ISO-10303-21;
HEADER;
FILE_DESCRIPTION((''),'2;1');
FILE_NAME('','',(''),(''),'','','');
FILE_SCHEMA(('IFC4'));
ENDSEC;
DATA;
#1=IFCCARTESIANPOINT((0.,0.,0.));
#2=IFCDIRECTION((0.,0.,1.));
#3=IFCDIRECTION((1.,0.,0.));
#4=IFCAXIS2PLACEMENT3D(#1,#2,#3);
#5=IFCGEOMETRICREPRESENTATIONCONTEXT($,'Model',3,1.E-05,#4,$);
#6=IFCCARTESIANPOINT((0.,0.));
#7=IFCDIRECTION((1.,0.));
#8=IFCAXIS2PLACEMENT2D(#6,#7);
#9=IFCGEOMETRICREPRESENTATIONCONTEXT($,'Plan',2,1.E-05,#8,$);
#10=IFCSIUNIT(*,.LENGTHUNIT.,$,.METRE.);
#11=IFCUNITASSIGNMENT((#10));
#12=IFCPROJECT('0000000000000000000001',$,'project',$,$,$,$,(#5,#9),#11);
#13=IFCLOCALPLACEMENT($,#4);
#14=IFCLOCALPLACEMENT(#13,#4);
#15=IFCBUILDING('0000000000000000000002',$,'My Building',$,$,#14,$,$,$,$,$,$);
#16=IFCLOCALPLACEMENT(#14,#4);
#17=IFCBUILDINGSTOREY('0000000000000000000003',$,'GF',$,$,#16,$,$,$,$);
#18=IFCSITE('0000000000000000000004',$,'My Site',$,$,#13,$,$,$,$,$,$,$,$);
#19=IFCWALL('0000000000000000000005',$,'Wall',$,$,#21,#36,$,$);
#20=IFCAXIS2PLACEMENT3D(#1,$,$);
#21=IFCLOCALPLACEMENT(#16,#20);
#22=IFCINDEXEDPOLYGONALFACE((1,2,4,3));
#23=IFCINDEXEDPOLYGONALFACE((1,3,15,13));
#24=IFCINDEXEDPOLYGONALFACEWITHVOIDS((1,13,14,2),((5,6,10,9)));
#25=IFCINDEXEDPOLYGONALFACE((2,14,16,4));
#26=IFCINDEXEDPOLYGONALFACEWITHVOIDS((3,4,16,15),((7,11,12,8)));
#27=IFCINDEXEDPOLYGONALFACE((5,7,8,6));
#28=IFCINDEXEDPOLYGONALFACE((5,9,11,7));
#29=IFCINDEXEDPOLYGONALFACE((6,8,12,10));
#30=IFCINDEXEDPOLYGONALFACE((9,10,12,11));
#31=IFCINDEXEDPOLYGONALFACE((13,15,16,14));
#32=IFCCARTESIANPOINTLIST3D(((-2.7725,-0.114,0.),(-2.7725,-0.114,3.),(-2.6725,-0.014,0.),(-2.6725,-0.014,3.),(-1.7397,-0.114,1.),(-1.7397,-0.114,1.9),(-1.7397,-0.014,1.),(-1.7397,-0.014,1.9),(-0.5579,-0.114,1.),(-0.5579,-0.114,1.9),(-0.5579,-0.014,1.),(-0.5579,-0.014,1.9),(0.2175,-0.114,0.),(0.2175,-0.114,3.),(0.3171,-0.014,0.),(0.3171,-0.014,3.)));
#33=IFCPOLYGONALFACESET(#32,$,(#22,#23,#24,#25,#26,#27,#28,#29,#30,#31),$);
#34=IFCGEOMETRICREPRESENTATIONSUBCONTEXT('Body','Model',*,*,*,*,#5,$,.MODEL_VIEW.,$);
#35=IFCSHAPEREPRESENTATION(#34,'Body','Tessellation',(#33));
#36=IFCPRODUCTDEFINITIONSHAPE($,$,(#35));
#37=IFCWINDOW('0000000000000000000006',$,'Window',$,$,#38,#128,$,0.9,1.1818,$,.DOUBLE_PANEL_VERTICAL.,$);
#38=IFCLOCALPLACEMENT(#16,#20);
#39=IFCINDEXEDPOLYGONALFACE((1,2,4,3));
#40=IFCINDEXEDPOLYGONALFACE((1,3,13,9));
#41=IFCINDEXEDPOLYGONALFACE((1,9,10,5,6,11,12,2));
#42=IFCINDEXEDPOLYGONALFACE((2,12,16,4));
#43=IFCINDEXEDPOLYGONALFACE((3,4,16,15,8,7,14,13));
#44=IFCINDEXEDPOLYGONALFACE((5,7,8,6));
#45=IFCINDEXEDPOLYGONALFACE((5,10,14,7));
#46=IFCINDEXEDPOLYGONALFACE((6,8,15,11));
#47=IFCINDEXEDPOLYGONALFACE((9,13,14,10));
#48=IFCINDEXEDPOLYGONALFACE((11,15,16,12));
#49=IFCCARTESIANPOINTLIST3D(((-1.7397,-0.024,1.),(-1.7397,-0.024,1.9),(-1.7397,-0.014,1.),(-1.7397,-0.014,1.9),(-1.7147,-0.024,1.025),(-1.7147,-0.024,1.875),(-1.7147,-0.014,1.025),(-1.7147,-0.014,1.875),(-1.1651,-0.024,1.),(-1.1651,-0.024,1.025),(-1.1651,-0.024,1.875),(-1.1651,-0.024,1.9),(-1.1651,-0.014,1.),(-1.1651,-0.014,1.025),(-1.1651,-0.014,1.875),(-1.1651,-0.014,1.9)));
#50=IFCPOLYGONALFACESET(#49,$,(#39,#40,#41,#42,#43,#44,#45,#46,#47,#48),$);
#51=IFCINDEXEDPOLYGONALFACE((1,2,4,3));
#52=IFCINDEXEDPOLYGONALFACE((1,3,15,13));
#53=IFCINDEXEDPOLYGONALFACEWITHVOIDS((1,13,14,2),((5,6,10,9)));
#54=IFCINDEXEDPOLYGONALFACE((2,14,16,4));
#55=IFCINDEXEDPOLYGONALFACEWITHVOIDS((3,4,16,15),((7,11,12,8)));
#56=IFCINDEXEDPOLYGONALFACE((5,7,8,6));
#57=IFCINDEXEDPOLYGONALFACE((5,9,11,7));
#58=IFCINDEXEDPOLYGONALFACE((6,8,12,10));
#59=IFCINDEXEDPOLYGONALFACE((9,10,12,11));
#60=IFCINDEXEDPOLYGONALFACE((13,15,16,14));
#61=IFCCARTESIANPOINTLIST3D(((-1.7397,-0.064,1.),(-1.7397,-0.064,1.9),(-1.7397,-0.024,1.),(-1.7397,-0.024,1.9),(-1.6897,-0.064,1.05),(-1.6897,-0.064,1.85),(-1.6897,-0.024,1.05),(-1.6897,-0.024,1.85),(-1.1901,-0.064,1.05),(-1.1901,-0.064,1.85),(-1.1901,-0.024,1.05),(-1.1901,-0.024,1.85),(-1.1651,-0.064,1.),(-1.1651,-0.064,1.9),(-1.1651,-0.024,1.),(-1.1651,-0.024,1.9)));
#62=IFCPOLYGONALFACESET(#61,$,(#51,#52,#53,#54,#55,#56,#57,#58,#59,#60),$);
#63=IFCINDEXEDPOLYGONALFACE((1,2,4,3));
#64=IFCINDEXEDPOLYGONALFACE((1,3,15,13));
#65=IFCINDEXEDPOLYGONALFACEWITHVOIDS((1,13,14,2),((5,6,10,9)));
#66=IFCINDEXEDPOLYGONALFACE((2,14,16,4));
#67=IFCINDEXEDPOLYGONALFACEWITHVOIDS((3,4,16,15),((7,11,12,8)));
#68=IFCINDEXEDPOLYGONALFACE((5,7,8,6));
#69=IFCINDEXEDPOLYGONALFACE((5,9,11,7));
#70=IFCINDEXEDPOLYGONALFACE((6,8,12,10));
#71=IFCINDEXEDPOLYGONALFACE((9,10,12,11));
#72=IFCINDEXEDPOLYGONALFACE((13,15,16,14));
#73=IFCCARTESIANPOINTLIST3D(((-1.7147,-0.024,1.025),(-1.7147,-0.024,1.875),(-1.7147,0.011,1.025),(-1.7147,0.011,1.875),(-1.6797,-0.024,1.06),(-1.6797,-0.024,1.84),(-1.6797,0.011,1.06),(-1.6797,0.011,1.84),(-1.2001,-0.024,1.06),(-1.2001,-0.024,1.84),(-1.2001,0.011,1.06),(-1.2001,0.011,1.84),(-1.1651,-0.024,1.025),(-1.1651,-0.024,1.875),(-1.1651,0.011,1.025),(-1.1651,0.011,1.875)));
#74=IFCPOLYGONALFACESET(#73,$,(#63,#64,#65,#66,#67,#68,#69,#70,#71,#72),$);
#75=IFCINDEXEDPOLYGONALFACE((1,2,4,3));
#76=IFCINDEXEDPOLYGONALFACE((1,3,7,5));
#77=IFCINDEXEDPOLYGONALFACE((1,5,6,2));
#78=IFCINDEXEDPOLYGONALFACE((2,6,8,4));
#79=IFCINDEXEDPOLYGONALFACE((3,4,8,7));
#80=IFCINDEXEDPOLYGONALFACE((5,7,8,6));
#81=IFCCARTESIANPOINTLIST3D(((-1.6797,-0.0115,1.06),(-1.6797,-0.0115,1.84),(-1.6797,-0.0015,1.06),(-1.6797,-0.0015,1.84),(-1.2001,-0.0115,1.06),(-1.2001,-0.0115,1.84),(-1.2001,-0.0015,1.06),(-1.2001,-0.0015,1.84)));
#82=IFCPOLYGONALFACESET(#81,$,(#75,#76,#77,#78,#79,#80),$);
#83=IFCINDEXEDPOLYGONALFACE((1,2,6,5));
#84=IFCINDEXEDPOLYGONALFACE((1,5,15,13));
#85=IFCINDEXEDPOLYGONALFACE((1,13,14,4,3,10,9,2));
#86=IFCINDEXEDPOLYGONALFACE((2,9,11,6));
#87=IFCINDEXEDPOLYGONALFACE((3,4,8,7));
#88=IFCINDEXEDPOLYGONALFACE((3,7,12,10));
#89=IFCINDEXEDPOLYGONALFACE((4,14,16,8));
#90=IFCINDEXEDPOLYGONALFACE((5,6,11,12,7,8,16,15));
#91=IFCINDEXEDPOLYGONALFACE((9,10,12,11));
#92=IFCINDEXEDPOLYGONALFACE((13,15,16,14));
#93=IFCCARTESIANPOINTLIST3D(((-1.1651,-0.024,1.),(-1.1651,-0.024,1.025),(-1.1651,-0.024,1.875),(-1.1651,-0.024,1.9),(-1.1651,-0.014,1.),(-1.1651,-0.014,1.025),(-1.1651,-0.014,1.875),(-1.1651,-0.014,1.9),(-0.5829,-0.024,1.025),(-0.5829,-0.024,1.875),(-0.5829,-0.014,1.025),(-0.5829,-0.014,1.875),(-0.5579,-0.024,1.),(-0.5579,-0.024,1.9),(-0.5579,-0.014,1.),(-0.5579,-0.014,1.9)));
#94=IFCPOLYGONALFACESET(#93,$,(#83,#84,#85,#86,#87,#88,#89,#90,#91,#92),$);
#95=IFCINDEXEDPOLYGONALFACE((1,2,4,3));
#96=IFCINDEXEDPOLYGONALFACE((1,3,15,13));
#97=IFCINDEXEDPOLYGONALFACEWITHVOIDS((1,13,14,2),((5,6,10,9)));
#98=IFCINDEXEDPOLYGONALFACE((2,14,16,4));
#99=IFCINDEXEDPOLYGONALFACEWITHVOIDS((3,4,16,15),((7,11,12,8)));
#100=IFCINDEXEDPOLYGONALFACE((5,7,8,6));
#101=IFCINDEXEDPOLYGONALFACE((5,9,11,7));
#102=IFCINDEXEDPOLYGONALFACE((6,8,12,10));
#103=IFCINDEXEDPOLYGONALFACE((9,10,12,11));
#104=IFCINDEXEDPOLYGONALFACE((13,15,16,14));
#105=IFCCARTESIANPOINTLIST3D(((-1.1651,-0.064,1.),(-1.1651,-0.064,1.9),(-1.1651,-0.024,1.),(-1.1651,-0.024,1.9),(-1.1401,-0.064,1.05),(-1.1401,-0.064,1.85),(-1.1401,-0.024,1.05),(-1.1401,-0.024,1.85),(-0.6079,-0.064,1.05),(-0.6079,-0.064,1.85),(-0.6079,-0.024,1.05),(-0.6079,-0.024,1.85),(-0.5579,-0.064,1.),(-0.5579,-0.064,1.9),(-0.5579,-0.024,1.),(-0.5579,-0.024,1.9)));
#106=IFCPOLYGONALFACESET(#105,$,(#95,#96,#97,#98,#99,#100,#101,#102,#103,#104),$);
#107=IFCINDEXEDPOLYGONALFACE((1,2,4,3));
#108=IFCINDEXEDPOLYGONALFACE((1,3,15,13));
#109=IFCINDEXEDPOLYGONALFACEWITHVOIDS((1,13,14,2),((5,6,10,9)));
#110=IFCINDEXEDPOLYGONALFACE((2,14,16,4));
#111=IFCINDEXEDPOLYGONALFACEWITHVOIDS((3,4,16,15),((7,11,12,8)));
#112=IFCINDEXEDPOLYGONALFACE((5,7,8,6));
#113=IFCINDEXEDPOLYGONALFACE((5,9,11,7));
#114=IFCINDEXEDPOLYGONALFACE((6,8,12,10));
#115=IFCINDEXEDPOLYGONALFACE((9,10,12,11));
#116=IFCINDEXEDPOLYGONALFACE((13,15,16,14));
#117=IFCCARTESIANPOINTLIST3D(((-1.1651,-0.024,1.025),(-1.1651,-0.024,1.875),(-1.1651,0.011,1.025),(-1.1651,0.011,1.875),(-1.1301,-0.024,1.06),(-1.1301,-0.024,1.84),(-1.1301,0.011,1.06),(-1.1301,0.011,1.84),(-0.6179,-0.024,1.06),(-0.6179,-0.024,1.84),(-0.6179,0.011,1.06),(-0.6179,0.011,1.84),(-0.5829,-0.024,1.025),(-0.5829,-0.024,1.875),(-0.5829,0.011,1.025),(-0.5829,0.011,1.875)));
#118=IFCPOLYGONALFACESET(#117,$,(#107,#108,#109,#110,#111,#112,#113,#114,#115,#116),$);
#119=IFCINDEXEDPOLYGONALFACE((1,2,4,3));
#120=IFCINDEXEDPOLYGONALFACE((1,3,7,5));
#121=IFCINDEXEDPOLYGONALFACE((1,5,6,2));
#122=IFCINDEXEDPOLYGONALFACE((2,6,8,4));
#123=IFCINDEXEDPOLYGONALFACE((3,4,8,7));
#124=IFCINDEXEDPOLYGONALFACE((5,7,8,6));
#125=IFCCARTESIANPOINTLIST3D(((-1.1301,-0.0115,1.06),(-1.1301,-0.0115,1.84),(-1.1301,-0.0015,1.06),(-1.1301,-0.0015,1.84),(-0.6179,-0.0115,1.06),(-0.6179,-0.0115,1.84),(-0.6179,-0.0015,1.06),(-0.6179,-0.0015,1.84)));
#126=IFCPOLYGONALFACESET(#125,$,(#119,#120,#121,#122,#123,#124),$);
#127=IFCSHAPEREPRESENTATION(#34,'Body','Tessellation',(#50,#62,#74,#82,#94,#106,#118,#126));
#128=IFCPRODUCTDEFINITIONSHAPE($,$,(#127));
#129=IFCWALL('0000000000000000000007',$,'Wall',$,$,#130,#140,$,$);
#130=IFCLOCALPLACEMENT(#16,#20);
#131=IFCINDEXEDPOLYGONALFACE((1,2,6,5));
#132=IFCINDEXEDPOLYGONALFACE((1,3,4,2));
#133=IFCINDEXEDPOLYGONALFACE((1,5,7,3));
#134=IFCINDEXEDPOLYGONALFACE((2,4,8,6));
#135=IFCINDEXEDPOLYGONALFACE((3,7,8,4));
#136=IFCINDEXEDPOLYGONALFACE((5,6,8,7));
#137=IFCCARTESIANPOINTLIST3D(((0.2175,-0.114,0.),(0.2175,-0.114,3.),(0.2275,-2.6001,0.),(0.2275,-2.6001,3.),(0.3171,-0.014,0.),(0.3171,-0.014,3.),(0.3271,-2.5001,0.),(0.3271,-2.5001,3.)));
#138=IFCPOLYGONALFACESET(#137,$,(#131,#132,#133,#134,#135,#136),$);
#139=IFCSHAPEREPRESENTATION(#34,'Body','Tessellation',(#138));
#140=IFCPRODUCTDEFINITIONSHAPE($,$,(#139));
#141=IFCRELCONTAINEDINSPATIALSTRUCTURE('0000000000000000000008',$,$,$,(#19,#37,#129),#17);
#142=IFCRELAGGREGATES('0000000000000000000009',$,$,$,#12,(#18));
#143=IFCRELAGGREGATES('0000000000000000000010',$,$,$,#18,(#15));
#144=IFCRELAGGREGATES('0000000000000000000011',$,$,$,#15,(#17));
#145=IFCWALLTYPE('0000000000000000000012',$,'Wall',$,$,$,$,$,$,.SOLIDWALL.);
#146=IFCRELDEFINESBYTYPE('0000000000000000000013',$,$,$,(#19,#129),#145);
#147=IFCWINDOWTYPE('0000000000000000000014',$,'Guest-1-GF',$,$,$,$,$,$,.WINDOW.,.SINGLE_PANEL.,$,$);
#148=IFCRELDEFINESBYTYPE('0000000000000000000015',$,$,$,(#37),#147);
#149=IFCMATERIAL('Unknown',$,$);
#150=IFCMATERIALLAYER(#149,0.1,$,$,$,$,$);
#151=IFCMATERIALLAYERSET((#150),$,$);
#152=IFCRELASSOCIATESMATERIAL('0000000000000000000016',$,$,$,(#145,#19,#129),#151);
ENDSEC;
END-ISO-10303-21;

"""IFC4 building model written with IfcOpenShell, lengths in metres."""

from ifc_helpers import new_model, entity, si_unit, frame, origin_with_axes, origin_2d_with_axis, place, context, subcontext, project, spatial, line, indexed_curve, outline, extrude, shape, source, transform, mapped, material, layer, layer_set, layer_usage, type_object, type_shapes, element, fill, save


model = new_model("IFC4")

# Units and contexts
model_context = context("Model", 3, precision=1e-05, world=origin_with_axes())
plan_context = context("Plan", 2, precision=1e-05, world=origin_2d_with_axis())
body_context_1 = subcontext(model_context, "Body", "Model", "MODEL_VIEW")
body_context_2 = subcontext(plan_context, "Body", "Plan", "PLAN_VIEW")
ifc_project = project(units=[si_unit("LENGTHUNIT", "METRE")], contexts=[model_context, plan_context])

# Site, building, storey
site_placement = place(None, origin_with_axes())
site = spatial("IfcSite", under=ifc_project, at=site_placement, Name="My Site")
building_placement = place(site_placement, origin_with_axes())
building = spatial("IfcBuilding", under=site, at=building_placement, Name="My Building")
storey_placement = place(building_placement, origin_with_axes())
storey = spatial("IfcBuildingStorey", under=building, at=storey_placement, Name="GF")

# Shared definitions
ifc_material = material(Name="Unknown")

# Shared definitions
ifc_layer_1 = layer(ifc_material, 0.1)
ifc_layer_set_1 = layer_set([ifc_layer_1])
wall_type = type_object("IfcWallType", Name="Wall", PredefinedType="SOLIDWALL", material=ifc_layer_set_1)

# Wall, opening, window
ifc_layer_usage_1 = layer_usage(ifc_layer_set_1, "AXIS2", "POSITIVE", 0.0)
wall_1_placement = place(storey_placement, frame((-2.7725, -0.114, 0.0), z_axis=(0.0, 0.0, 1.0), x_axis=(1.0, 0.0, 0.0)))
wall_1 = element("IfcWall", 1, at=wall_1_placement, inside=storey, type_object=wall_type, material=ifc_layer_usage_1, Name="Wall", context=body_context_1, shape_type="SweptSolid", body=[
    extrude(outline(indexed_curve([(0.0, 0.0), (0.1, 0.1), (3.0896, 0.1), (2.99, 0.0)], segments=[line(1, 2, 3, 4, 1)])), origin_with_axes(), (0.0, 0.0, 1.0), 3.0),
])
shared_shape_1 = source(origin_with_axes(), body_context_1, "Body", "SweptSolid", [
    extrude(outline(indexed_curve([(0.0, 0.0), (1.1818, 0.0), (1.1818, 0.9), (0.0, 0.9)], segments=[line(1, 2, 3, 4, 1)])), frame((0.0, -0.6, 0.0), z_axis=(0.0, -1.0, 0.0), x_axis=(1.0, 0.0, 0.0)), (0.0, 0.0, -1.0), 1.2),
])
opening_1_placement = place(wall_1_placement, frame((1.0328, 0.0, 1.0), z_axis=(0.0, 0.0, 1.0), x_axis=(1.0, 0.0, 0.0)))
opening_1 = element("IfcOpeningElement", 2, at=opening_1_placement, cuts=wall_1, PredefinedType="OPENING", context=body_context_1, shape_type="MappedRepresentation", body=[
    mapped(shared_shape_1, transform((0.0, 0.0, 0.0), x_axis=(1.0, 0.0, 0.0), y_axis=(0.0, 1.0, 0.0), z_axis=(0.0, 0.0, 1.0), scale=1.0)),
])
window_type_1 = type_object("IfcWindowType", Name="Guest-1-GF", PartitioningType="SINGLE_PANEL", PredefinedType="WINDOW")
shared_shape_2 = source(origin_with_axes(), body_context_1, "Body", "SweptSolid", [
    extrude(outline(indexed_curve([(0.5746, 0.0), (0.0, 0.0), (0.0, 0.9), (0.5746, 0.9), (0.5746, 0.875), (0.025, 0.875), (0.025, 0.025), (0.5746, 0.025)], segments=[line(1, 2, 3, 4, 5, 6, 7, 8, 1)])), frame((0.0, 0.09, 0.0), z_axis=(0.0, -1.0, 0.0), x_axis=(1.0, 0.0, 0.0)), (0.0, 0.0, -1.0), 0.01),
    extrude(outline(indexed_curve([(0.0, 0.0), (0.5746, 0.0), (0.5746, 0.9), (0.0, 0.9)], segments=[line(1, 2, 3, 4, 1)]), holes=[indexed_curve([(0.05, 0.05), (0.5496, 0.05), (0.5496, 0.85), (0.05, 0.85)], segments=[line(1, 2, 3, 4, 1)])]), frame((0.0, 0.05, 0.0), z_axis=(0.0, -1.0, 0.0), x_axis=(1.0, 0.0, 0.0)), (0.0, 0.0, -1.0), 0.04),
    extrude(outline(indexed_curve([(0.0, 0.0), (0.5496, 0.0), (0.5496, 0.85), (0.0, 0.85)], segments=[line(1, 2, 3, 4, 1)]), holes=[indexed_curve([(0.035, 0.035), (0.5146, 0.035), (0.5146, 0.815), (0.035, 0.815)], segments=[line(1, 2, 3, 4, 1)])]), frame((0.025, 0.09, 0.025), z_axis=(0.0, -1.0, 0.0), x_axis=(1.0, 0.0, 0.0)), (0.0, 0.0, -1.0), 0.035),
    extrude(outline(indexed_curve([(0.035, 0.035), (0.5146, 0.035), (0.5146, 0.815), (0.035, 0.815)], segments=[line(1, 2, 3, 4, 1)])), frame((0.025, 0.1025, 0.025), z_axis=(0.0, -1.0, 0.0), x_axis=(1.0, 0.0, 0.0)), (0.0, 0.0, -1.0), 0.01),
    extrude(outline(indexed_curve([(0.0, 0.9), (0.6072, 0.9), (0.6072, 0.0), (0.0, 0.0), (0.0, 0.025), (0.5822, 0.025), (0.5822, 0.875), (0.0, 0.875)], segments=[line(1, 2, 3, 4, 5, 6, 7, 8, 1)])), frame((0.5746, 0.09, 0.0), z_axis=(0.0, -1.0, 0.0), x_axis=(1.0, 0.0, 0.0)), (0.0, 0.0, -1.0), 0.01),
    extrude(outline(indexed_curve([(0.0, 0.0), (0.6072, 0.0), (0.6072, 0.9), (0.0, 0.9)], segments=[line(1, 2, 3, 4, 1)]), holes=[indexed_curve([(0.025, 0.05), (0.5572, 0.05), (0.5572, 0.85), (0.025, 0.85)], segments=[line(1, 2, 3, 4, 1)])]), frame((0.5746, 0.05, 0.0), z_axis=(0.0, -1.0, 0.0), x_axis=(1.0, 0.0, 0.0)), (0.0, 0.0, -1.0), 0.04),
    extrude(outline(indexed_curve([(0.0, 0.0), (0.5822, 0.0), (0.5822, 0.85), (0.0, 0.85)], segments=[line(1, 2, 3, 4, 1)]), holes=[indexed_curve([(0.035, 0.035), (0.5472, 0.035), (0.5472, 0.815), (0.035, 0.815)], segments=[line(1, 2, 3, 4, 1)])]), frame((0.5746, 0.09, 0.025), z_axis=(0.0, -1.0, 0.0), x_axis=(1.0, 0.0, 0.0)), (0.0, 0.0, -1.0), 0.035),
    extrude(outline(indexed_curve([(0.035, 0.035), (0.5472, 0.035), (0.5472, 0.815), (0.035, 0.815)], segments=[line(1, 2, 3, 4, 1)])), frame((0.5746, 0.1025, 0.025), z_axis=(0.0, -1.0, 0.0), x_axis=(1.0, 0.0, 0.0)), (0.0, 0.0, -1.0), 0.01),
])
shared_shape_3 = source(origin_with_axes(), body_context_2, "Body", "Curve2D", [
    entity("IfcIndexedPolyCurve", entity("IfcCartesianPointList2D", [[0.05, 0.05], [0.5496, 0.05]])),
    entity("IfcIndexedPolyCurve", entity("IfcCartesianPointList2D", [[0.0, 0.1], [0.025, 0.1], [0.025, 0.09], [0.05, 0.09], [0.05, 0.05], [0.0, 0.05]]), [entity("IfcLineIndex", [1, 2, 3, 4, 5, 6, 1])]),
    entity("IfcIndexedPolyCurve", entity("IfcCartesianPointList2D", [[0.5746, 0.1], [0.5746, 0.1], [0.5746, 0.09], [0.5496, 0.09], [0.5496, 0.05], [0.5746, 0.05]])),
    entity("IfcIndexedPolyCurve", entity("IfcCartesianPointList2D", [[0.025, 0.09], [0.06, 0.09], [0.06, 0.125], [0.025, 0.125]]), [entity("IfcLineIndex", [1, 2, 3, 4, 1])]),
    entity("IfcIndexedPolyCurve", entity("IfcCartesianPointList2D", [[0.5746, 0.09], [0.5396, 0.09], [0.5396, 0.125], [0.5746, 0.125]]), [entity("IfcLineIndex", [1, 2, 3, 4, 1])]),
    entity("IfcIndexedPolyCurve", entity("IfcCartesianPointList2D", [[0.06, 0.09], [0.5396, 0.09]])),
    entity("IfcIndexedPolyCurve", entity("IfcCartesianPointList2D", [[0.06, 0.125], [0.5396, 0.125]])),
    entity("IfcIndexedPolyCurve", entity("IfcCartesianPointList2D", [[0.06, 0.1075], [0.5396, 0.1075]])),
    entity("IfcIndexedPolyCurve", entity("IfcCartesianPointList2D", [[0.5996, 0.05], [1.1318, 0.05]])),
    entity("IfcIndexedPolyCurve", entity("IfcCartesianPointList2D", [[0.5746, 0.1], [0.5746, 0.1], [0.5746, 0.09], [0.5996, 0.09], [0.5996, 0.05], [0.5746, 0.05]])),
    entity("IfcIndexedPolyCurve", entity("IfcCartesianPointList2D", [[1.1818, 0.1], [1.1568, 0.1], [1.1568, 0.09], [1.1318, 0.09], [1.1318, 0.05], [1.1818, 0.05]]), [entity("IfcLineIndex", [1, 2, 3, 4, 5, 6, 1])]),
    entity("IfcIndexedPolyCurve", entity("IfcCartesianPointList2D", [[0.5746, 0.09], [0.6096, 0.09], [0.6096, 0.125], [0.5746, 0.125]]), [entity("IfcLineIndex", [1, 2, 3, 4, 1])]),
    entity("IfcIndexedPolyCurve", entity("IfcCartesianPointList2D", [[1.1568, 0.09], [1.1218, 0.09], [1.1218, 0.125], [1.1568, 0.125]]), [entity("IfcLineIndex", [1, 2, 3, 4, 1])]),
    entity("IfcIndexedPolyCurve", entity("IfcCartesianPointList2D", [[0.6096, 0.09], [1.1218, 0.09]])),
    entity("IfcIndexedPolyCurve", entity("IfcCartesianPointList2D", [[0.6096, 0.125], [1.1218, 0.125]])),
    entity("IfcIndexedPolyCurve", entity("IfcCartesianPointList2D", [[0.6096, 0.1075], [1.1218, 0.1075]])),
])
type_shapes(window_type_1, [shared_shape_2, shared_shape_3])
window_1_placement = place(opening_1_placement, frame((0.0, 0.0, 0.0), z_axis=(0.0, 0.0, 1.0), x_axis=(1.0, 0.0, 0.0)))
window_1 = element("IfcWindow", 3, at=window_1_placement, inside=storey, type_object=window_type_1, Name="Window", OverallHeight=0.9, OverallWidth=1.1818, PartitioningType="DOUBLE_PANEL_VERTICAL", shapes=[
    shape(body_context_1, "Body", "MappedRepresentation", [mapped(shared_shape_2, transform((0.0, 0.0, 0.0), x_axis=(1.0, 0.0, 0.0), y_axis=(0.0, 1.0, 0.0), z_axis=(0.0, 0.0, 1.0), scale=1.0))]),
    shape(body_context_2, "Body", "MappedRepresentation", [mapped(shared_shape_3, transform((0.0, 0.0, 0.0), x_axis=(1.0, 0.0, 0.0), y_axis=(0.0, 1.0, 0.0), z_axis=(0.0, 0.0, 1.0), scale=1.0))]),
])
fill(opening_1, window_1)

# Wall
ifc_layer_usage_2 = layer_usage(ifc_layer_set_1, "AXIS2", "POSITIVE", 0.0)
wall_2_placement = place(storey_placement, frame((0.2175, -0.114, 0.0), z_axis=(0.0, 0.0, 1.0), x_axis=(0.004022, -0.999992, 0.0)))
element("IfcWall", 4, at=wall_2_placement, inside=storey, type_object=wall_type, material=ifc_layer_usage_2, Name="Wall", context=body_context_1, shape_type="SweptSolid", body=[
    extrude(outline(indexed_curve([(0.0, 0.0), (-0.0996, 0.1), (2.3865, 0.1), (2.4861, 0.0)], segments=[line(1, 2, 3, 4, 1)])), origin_with_axes(), (0.0, 0.0, 1.0), 3.0),
])

save(model, "model.ifc")
